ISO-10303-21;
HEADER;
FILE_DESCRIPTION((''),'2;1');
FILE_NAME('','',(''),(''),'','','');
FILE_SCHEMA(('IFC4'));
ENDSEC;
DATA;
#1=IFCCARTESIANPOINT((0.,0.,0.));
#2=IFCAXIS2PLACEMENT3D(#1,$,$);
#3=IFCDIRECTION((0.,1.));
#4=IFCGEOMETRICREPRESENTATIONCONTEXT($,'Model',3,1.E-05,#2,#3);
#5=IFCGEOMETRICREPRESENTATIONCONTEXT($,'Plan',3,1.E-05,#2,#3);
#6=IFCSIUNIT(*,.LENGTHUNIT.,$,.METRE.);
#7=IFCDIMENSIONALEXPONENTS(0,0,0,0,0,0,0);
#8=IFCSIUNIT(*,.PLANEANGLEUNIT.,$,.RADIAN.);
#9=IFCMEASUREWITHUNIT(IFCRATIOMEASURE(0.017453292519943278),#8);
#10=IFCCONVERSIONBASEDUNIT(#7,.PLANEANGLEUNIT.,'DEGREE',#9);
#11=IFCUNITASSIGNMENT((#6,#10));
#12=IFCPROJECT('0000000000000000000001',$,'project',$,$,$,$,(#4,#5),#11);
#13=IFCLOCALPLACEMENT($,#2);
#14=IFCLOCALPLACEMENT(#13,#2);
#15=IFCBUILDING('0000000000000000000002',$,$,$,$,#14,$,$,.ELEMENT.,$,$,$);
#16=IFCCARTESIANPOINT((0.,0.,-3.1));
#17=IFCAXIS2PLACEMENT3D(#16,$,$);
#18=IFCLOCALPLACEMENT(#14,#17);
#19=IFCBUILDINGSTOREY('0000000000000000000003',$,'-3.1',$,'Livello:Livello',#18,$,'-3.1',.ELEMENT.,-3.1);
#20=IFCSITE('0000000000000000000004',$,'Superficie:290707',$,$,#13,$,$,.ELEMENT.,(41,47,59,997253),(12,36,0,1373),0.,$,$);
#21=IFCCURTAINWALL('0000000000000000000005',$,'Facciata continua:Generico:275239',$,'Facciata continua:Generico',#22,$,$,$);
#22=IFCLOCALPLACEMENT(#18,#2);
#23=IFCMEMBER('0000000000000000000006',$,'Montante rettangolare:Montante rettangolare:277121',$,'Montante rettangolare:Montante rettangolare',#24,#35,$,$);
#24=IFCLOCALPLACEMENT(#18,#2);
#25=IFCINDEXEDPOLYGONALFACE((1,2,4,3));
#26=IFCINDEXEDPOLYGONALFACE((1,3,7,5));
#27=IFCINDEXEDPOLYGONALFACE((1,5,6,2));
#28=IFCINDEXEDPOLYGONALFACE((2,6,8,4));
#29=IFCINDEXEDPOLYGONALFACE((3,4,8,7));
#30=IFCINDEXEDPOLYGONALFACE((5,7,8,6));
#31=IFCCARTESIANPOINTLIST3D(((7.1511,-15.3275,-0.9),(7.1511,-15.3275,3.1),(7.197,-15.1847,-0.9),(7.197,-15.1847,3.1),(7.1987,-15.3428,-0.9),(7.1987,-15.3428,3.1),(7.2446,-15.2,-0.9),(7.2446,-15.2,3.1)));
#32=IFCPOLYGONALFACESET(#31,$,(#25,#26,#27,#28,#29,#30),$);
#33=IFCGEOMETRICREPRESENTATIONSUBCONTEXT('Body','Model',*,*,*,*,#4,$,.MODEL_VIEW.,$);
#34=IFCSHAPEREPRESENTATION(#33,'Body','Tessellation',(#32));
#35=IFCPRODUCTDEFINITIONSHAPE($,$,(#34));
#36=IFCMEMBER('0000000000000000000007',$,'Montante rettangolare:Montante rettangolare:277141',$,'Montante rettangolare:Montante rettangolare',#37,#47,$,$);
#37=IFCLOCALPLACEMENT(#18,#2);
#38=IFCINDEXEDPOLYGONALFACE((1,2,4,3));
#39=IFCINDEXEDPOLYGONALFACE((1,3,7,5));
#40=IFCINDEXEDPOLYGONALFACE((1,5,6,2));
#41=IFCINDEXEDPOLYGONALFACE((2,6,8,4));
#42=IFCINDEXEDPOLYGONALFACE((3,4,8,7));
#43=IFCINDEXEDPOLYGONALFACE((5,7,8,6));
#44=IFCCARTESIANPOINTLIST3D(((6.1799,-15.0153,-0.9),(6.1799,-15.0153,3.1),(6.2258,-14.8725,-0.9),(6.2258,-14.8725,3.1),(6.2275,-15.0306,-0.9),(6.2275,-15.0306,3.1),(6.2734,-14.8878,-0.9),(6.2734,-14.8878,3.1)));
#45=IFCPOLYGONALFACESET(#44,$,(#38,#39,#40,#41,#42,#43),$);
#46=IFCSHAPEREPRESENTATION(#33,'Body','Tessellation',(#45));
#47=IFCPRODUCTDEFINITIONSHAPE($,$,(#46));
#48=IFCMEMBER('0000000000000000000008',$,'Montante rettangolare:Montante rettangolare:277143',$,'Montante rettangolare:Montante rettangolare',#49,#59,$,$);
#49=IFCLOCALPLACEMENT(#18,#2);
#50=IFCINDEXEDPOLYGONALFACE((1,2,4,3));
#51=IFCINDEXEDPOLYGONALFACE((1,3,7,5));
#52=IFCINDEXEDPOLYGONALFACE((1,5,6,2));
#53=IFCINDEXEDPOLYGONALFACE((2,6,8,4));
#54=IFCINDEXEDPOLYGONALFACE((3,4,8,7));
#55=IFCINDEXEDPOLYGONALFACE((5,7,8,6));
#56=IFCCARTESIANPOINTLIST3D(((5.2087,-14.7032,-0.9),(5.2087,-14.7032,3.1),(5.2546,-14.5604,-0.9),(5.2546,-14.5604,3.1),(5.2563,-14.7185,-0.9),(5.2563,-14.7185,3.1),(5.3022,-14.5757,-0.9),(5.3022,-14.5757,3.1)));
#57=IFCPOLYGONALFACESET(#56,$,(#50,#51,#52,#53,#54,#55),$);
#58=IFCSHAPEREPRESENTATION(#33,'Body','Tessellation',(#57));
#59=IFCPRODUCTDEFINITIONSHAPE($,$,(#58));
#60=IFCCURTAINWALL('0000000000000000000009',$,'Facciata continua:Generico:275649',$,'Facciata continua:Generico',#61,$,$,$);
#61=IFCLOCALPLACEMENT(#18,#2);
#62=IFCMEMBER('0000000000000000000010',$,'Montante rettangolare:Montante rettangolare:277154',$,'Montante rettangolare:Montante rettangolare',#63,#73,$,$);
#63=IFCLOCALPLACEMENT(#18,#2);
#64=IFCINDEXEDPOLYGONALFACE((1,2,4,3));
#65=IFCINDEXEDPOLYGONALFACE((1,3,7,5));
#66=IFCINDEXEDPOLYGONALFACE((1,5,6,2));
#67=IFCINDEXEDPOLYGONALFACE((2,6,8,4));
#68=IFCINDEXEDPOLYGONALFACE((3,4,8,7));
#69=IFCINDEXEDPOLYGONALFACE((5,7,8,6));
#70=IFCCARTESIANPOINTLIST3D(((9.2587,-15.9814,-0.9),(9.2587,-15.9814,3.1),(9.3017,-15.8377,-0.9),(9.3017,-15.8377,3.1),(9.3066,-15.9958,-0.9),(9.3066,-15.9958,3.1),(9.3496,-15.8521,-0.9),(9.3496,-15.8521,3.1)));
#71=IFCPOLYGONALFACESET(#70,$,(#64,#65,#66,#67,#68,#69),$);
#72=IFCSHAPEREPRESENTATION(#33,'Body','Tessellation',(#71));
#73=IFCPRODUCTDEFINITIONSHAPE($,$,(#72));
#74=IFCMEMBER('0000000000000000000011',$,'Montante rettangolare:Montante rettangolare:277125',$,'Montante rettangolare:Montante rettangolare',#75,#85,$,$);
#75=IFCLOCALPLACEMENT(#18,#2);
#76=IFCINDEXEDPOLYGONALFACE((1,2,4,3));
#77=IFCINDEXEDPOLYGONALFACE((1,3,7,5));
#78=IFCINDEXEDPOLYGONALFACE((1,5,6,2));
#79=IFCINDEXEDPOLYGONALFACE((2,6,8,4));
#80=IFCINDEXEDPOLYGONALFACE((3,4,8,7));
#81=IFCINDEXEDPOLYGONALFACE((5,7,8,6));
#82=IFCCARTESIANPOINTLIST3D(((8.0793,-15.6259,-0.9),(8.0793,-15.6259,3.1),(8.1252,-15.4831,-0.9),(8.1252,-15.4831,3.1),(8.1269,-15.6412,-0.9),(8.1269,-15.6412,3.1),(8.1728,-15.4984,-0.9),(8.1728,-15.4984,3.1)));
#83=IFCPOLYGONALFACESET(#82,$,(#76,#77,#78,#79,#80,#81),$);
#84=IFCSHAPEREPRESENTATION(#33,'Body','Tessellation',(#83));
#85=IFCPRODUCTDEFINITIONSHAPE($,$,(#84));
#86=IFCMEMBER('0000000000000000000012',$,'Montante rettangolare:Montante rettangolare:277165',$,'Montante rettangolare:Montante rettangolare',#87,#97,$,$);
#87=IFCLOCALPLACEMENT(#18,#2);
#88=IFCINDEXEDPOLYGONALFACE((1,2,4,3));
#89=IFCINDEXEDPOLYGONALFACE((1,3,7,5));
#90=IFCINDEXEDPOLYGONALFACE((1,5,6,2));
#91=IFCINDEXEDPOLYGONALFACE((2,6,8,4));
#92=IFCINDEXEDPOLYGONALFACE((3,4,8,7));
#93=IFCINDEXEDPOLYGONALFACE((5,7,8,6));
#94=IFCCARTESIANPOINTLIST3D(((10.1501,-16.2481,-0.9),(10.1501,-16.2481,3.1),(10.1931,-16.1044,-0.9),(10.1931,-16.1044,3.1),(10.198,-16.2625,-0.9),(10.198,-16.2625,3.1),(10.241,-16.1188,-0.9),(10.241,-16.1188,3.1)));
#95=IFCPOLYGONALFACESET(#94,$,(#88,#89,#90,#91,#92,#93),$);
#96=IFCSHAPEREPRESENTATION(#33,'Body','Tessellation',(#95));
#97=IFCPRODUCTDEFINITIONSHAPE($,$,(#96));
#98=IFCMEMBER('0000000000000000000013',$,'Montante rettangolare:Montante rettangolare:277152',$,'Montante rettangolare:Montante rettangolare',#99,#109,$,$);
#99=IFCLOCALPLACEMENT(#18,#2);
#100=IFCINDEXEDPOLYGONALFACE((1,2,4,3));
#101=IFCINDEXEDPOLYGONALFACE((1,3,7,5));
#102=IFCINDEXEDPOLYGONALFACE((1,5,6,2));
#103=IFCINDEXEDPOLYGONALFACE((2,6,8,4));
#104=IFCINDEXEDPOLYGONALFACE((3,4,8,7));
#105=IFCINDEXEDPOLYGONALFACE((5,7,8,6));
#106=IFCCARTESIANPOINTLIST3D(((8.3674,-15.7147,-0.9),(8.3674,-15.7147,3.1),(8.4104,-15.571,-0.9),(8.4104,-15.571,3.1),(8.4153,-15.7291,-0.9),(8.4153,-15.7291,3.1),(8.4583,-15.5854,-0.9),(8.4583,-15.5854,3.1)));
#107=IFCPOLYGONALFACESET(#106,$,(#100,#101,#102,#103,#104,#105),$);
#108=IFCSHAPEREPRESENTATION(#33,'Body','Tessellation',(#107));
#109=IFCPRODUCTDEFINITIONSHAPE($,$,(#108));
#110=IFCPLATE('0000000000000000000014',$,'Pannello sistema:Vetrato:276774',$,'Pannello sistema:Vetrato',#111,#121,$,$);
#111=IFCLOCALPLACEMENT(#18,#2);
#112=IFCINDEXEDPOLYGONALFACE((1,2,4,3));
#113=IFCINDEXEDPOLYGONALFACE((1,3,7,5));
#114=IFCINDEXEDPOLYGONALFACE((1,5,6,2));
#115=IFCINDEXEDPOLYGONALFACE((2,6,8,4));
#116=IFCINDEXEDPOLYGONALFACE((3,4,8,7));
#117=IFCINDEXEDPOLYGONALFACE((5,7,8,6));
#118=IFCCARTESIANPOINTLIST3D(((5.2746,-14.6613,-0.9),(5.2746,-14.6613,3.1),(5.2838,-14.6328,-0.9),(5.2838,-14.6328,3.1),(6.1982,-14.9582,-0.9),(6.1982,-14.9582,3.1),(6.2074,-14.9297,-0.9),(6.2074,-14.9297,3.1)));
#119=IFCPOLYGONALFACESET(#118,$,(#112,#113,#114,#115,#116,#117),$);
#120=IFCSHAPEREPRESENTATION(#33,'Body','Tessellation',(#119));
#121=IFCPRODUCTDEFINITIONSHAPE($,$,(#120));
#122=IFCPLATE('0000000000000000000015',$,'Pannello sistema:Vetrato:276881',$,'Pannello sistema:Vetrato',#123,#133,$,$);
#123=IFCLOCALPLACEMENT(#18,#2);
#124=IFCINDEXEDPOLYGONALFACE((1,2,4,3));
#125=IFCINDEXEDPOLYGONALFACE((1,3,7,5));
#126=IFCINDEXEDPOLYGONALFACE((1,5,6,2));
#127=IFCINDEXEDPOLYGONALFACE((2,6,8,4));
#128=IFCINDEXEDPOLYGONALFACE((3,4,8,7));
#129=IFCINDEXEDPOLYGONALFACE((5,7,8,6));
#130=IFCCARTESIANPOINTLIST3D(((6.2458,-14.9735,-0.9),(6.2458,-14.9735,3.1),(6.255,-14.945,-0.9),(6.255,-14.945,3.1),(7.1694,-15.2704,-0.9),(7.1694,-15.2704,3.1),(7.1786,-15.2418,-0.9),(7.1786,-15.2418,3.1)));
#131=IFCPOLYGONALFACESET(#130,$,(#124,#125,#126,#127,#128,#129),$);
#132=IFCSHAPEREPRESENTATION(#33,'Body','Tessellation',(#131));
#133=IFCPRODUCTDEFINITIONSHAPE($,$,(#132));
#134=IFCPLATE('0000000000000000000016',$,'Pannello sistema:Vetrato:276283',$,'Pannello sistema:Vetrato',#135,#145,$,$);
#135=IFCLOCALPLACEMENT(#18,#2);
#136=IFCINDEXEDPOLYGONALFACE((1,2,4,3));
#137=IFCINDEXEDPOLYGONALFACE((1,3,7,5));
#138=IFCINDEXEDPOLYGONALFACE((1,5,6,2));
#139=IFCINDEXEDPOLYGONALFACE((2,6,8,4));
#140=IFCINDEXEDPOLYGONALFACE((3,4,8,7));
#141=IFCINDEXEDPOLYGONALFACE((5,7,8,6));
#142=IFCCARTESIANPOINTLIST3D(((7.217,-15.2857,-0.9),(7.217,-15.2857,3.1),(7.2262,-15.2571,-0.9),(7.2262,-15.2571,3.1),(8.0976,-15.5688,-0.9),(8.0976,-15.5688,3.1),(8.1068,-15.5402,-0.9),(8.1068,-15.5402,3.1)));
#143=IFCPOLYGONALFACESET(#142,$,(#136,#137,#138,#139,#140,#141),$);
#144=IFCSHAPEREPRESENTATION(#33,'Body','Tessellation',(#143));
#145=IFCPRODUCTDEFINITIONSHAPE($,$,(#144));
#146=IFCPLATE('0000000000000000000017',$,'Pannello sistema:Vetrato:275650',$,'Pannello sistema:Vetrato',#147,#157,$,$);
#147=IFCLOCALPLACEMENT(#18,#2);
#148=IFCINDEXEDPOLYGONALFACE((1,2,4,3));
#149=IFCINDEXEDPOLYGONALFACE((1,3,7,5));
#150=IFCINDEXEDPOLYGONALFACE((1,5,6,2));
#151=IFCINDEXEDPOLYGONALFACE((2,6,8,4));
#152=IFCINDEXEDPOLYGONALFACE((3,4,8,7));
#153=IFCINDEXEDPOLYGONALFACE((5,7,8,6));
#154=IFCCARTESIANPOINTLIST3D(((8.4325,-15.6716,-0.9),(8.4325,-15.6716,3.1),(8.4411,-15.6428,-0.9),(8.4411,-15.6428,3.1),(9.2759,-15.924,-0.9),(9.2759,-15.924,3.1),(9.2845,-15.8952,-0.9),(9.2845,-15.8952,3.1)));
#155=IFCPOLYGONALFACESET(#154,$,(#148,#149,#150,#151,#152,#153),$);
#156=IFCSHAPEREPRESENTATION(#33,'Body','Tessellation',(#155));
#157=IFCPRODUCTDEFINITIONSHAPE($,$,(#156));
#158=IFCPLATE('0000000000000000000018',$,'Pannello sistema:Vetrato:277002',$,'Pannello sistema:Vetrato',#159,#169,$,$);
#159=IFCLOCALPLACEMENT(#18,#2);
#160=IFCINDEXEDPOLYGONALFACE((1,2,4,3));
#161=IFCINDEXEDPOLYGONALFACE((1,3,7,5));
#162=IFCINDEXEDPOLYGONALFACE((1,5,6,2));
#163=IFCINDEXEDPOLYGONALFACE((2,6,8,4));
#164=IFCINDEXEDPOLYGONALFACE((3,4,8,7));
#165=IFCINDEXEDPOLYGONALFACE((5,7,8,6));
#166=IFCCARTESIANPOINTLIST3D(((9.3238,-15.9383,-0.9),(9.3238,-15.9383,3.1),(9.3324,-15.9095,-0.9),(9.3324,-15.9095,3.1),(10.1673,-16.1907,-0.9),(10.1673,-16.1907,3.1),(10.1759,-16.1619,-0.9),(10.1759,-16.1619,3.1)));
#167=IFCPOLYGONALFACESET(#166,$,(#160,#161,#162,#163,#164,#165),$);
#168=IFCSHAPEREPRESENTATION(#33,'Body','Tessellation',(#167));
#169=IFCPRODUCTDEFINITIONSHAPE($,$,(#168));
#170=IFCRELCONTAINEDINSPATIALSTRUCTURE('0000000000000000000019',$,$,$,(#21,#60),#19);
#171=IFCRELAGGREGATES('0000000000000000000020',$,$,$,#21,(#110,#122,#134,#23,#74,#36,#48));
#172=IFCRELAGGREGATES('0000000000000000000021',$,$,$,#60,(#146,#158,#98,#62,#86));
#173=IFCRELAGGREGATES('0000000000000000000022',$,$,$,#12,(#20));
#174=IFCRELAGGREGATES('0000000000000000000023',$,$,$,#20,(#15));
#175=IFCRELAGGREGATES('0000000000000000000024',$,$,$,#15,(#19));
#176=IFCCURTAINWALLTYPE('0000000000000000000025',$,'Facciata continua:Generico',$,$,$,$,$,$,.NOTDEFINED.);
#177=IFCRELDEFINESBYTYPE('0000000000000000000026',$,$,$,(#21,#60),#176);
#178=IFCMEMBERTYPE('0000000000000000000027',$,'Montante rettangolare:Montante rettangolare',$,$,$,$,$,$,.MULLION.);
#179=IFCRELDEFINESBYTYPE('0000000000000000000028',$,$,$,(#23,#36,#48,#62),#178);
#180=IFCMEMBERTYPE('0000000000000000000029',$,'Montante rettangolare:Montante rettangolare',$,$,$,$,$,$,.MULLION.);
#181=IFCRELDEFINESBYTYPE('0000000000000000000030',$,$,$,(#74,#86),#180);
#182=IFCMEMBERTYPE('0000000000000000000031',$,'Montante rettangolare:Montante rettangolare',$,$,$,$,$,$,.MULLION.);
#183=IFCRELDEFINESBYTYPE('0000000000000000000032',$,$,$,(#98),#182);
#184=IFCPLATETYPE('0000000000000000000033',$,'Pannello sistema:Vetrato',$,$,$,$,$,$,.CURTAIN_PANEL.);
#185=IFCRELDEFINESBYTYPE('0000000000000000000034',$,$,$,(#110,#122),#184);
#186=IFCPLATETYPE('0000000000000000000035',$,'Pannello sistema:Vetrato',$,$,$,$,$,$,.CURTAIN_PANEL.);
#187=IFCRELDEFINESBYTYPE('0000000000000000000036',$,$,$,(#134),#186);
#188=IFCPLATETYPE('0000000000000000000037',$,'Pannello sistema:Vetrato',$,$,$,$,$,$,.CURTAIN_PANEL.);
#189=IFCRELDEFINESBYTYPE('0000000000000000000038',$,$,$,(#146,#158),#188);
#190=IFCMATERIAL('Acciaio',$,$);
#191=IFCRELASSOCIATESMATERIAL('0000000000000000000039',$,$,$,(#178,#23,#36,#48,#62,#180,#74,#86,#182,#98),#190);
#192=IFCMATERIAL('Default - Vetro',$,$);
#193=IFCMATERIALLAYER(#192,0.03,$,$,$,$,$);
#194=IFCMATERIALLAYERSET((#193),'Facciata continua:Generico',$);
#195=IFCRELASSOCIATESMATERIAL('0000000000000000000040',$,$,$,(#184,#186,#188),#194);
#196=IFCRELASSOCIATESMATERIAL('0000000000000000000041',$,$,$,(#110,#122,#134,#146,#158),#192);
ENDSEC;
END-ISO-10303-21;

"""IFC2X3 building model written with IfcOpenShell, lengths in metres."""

from ifc_helpers import new_model, entity, si_unit, converted_unit, direction, frame, frame_2d, origin, origin_2d_with_axis, place, context, subcontext, project, spatial, rectangle, extrude, source, transform, mapped, material, layer, layer_set, type_object, type_shapes, element, aggregate, save


model = new_model("IFC2X3")

# Units and contexts
model_context = context("Model", 3, precision=1e-05, world=origin(), true_north=direction((0.0, 1.0)))
plan_context = context("Plan", 3, precision=1e-05, world=origin(), true_north=direction((0.0, 1.0)))
body_context = subcontext(model_context, "Body", "Model", "MODEL_VIEW")
ifc_project = project(units=[si_unit("LENGTHUNIT", "METRE"), converted_unit("PLANEANGLEUNIT", "DEGREE", entity("IfcRatioMeasure", 0.017453292519943278), si_unit("PLANEANGLEUNIT", "RADIAN"), dimensions=[0, 0, 0, 0, 0, 0, 0])], contexts=[model_context, plan_context])

# Site, building, storey
site_placement = place(None, origin())
site = spatial("IfcSite", under=ifc_project, at=site_placement, Name="Superficie:290707", CompositionType="ELEMENT", RefLatitude=(41, 47, 59, 997253), RefLongitude=(12, 36, 0, 1373), RefElevation=0.0)
building_placement = place(site_placement, origin())
building = spatial("IfcBuilding", under=site, at=building_placement, CompositionType="ELEMENT")
storey_placement = place(building_placement, frame((0.0, 0.0, -3.1)))
storey = spatial("IfcBuildingStorey", under=building, at=storey_placement, Name="-3.1", ObjectType="Livello:Livello", LongName="-3.1", CompositionType="ELEMENT", Elevation=-3.1)

# Curtain wall, members
curtain_wall_type = type_object("IfcCurtainWallType", Name="Facciata continua:Generico", PredefinedType="NOTDEFINED")
curtain_wall_1_placement = place(storey_placement, frame((0.0, 0.0, 3.1)))
curtain_wall_1 = element("IfcCurtainWall", 1, at=curtain_wall_1_placement, inside=storey, type_object=curtain_wall_type, Name="Facciata continua:Generico:275239", ObjectType="Facciata continua:Generico")
ifc_material_1 = material(Name="Acciaio")
member_type_1 = type_object("IfcMemberType", Name="Montante rettangolare:Montante rettangolare", PredefinedType="MULLION", material=ifc_material_1)
shared_shape_1 = source(origin(), body_context, "Body", "SweptSolid", [
    extrude(rectangle(XDim=0.15, YDim=0.05, at=origin_2d_with_axis()), frame((0.0, 0.0, -4.0), z_axis=(0.0, 0.0, 1.0), x_axis=(0.0, -1.0, 0.0)), (0.0, 0.0, 1.0), 4.0),
])
type_shapes(member_type_1, [shared_shape_1])
member_1_placement = place(curtain_wall_1_placement, frame((7.1978, -15.2638, -4.0), z_axis=(0.0, 0.0, -1.0), x_axis=(0.952025, -0.30602, 0.0)))
member_1 = element("IfcMember", 2, at=member_1_placement, type_object=member_type_1, material=ifc_material_1, Name="Montante rettangolare:Montante rettangolare:277121", ObjectType="Montante rettangolare:Montante rettangolare", context=body_context, shape_type="MappedRepresentation", body=[
    mapped(shared_shape_1, transform((0.0, 0.0, 0.0), scale=1.0)),
])
member_2_placement = place(curtain_wall_1_placement, frame((6.2266, -14.9516, -4.0), z_axis=(0.0, 0.0, -1.0), x_axis=(0.952025, -0.30602, 0.0)))
member_2 = element("IfcMember", 3, at=member_2_placement, type_object=member_type_1, material=ifc_material_1, Name="Montante rettangolare:Montante rettangolare:277141", ObjectType="Montante rettangolare:Montante rettangolare", context=body_context, shape_type="MappedRepresentation", body=[
    mapped(shared_shape_1, transform((0.0, 0.0, 0.0), scale=1.0)),
])
member_3_placement = place(curtain_wall_1_placement, frame((5.2554, -14.6394, -4.0), z_axis=(0.0, 0.0, -1.0), x_axis=(0.952025, -0.30602, 0.0)))
member_3 = element("IfcMember", 4, at=member_3_placement, type_object=member_type_1, material=ifc_material_1, Name="Montante rettangolare:Montante rettangolare:277143", ObjectType="Montante rettangolare:Montante rettangolare", context=body_context, shape_type="MappedRepresentation", body=[
    mapped(shared_shape_1, transform((0.0, 0.0, 0.0), scale=1.0)),
])

# Curtain wall, member
curtain_wall_2_placement = place(storey_placement, frame((0.0, 0.0, 3.1)))
curtain_wall_2 = element("IfcCurtainWall", 5, at=curtain_wall_2_placement, inside=storey, type_object=curtain_wall_type, Name="Facciata continua:Generico:275649", ObjectType="Facciata continua:Generico")
member_4_placement = place(curtain_wall_2_placement, frame((9.3042, -15.9168, -4.0), z_axis=(0.0, 0.0, -1.0), x_axis=(0.95803, -0.286666, 0.0)))
member_4 = element("IfcMember", 6, at=member_4_placement, type_object=member_type_1, material=ifc_material_1, Name="Montante rettangolare:Montante rettangolare:277154", ObjectType="Montante rettangolare:Montante rettangolare", context=body_context, shape_type="MappedRepresentation", body=[
    mapped(shared_shape_1, transform((0.0, 0.0, 0.0), scale=1.0)),
])

# Members
member_type_2 = type_object("IfcMemberType", Name="Montante rettangolare:Montante rettangolare", PredefinedType="MULLION", material=ifc_material_1)
shared_shape_2 = source(origin(), body_context, "Body", "SweptSolid", [
    extrude(rectangle(XDim=0.15, YDim=0.05, at=origin_2d_with_axis()), frame((-0.025, 0.0, -4.0), z_axis=(0.0, 0.0, 1.0), x_axis=(0.0, -1.0, 0.0)), (0.0, 0.0, 1.0), 4.0),
])
type_shapes(member_type_2, [shared_shape_2])
member_5_placement = place(curtain_wall_1_placement, frame((8.1498, -15.5698, -4.0), z_axis=(0.0, 0.0, -1.0), x_axis=(0.952025, -0.30602, 0.0)))
member_5 = element("IfcMember", 7, at=member_5_placement, type_object=member_type_2, material=ifc_material_1, Name="Montante rettangolare:Montante rettangolare:277125", ObjectType="Montante rettangolare:Montante rettangolare", context=body_context, shape_type="MappedRepresentation", body=[
    mapped(shared_shape_2, transform((0.0, 0.0, 0.0), scale=1.0)),
])
member_6_placement = place(curtain_wall_2_placement, frame((10.2195, -16.1906, -4.0), z_axis=(0.0, 0.0, -1.0), x_axis=(0.95803, -0.286666, 0.0)))
member_6 = element("IfcMember", 8, at=member_6_placement, type_object=member_type_2, material=ifc_material_1, Name="Montante rettangolare:Montante rettangolare:277165", ObjectType="Montante rettangolare:Montante rettangolare", context=body_context, shape_type="MappedRepresentation", body=[
    mapped(shared_shape_2, transform((0.0, 0.0, 0.0), scale=1.0)),
])
member_type_3 = type_object("IfcMemberType", Name="Montante rettangolare:Montante rettangolare", PredefinedType="MULLION", material=ifc_material_1)
shared_shape_3 = source(origin(), body_context, "Body", "SweptSolid", [
    extrude(rectangle(XDim=0.15, YDim=0.05, at=origin_2d_with_axis()), frame((-0.025, 0.0, -4.0), z_axis=(0.0, 0.0, 1.0), x_axis=(0.0, -1.0, 0.0)), (0.0, 0.0, 1.0), 4.0),
])
type_shapes(member_type_3, [shared_shape_3])
member_7_placement = place(curtain_wall_2_placement, frame((8.3889, -15.6429, 0.0), z_axis=(0.0, 0.0, 1.0), x_axis=(-0.95803, 0.286666, 0.0)))
member_7 = element("IfcMember", 9, at=member_7_placement, type_object=member_type_3, material=ifc_material_1, Name="Montante rettangolare:Montante rettangolare:277152", ObjectType="Montante rettangolare:Montante rettangolare", context=body_context, shape_type="MappedRepresentation", body=[
    mapped(shared_shape_3, transform((0.0, 0.0, 0.0), scale=1.0)),
])

# Plates
ifc_material_2 = material(Name="Default - Vetro")
ifc_layer_1 = layer(ifc_material_2, 0.03)
ifc_layer_set_1 = layer_set([ifc_layer_1], Name="Facciata continua:Generico")
plate_type_1 = type_object("IfcPlateType", Name="Pannello sistema:Vetrato", PredefinedType="CURTAIN_PANEL", material=ifc_layer_set_1)
shared_shape_4 = source(origin(), body_context, "Body", "SweptSolid", [
    extrude(rectangle(XDim=0.03, YDim=0.9701, at=frame_2d((0.0, 0.0), x_axis=(1.0, 0.0))), frame((0.0, 0.0, 0.0), z_axis=(0.0, 0.0, 1.0), x_axis=(0.0, 1.0, 0.0)), (0.0, 0.0, 1.0), 4.0),
])
type_shapes(plate_type_1, [shared_shape_4])
plate_1_placement = place(curtain_wall_1_placement, frame((5.741, -14.7955, -4.0), z_axis=(0.0, 0.0, 1.0), x_axis=(0.952025, -0.30602, 0.0)))
plate_1 = element("IfcPlate", 10, at=plate_1_placement, type_object=plate_type_1, material=ifc_material_2, Name="Pannello sistema:Vetrato:276774", ObjectType="Pannello sistema:Vetrato", context=body_context, shape_type="MappedRepresentation", body=[
    mapped(shared_shape_4, transform((0.0, 0.0, 0.0), scale=1.0)),
])
plate_2_placement = place(curtain_wall_1_placement, frame((6.7122, -15.1077, -4.0), z_axis=(0.0, 0.0, 1.0), x_axis=(0.952025, -0.30602, 0.0)))
plate_2 = element("IfcPlate", 11, at=plate_2_placement, type_object=plate_type_1, material=ifc_material_2, Name="Pannello sistema:Vetrato:276881", ObjectType="Pannello sistema:Vetrato", context=body_context, shape_type="MappedRepresentation", body=[
    mapped(shared_shape_4, transform((0.0, 0.0, 0.0), scale=1.0)),
])
plate_type_2 = type_object("IfcPlateType", Name="Pannello sistema:Vetrato", PredefinedType="CURTAIN_PANEL", material=ifc_layer_set_1)
shared_shape_5 = source(origin(), body_context, "Body", "SweptSolid", [
    extrude(rectangle(XDim=0.03, YDim=0.925, at=frame_2d((0.0, 0.0), x_axis=(1.0, 0.0))), frame((0.0, 0.0, 0.0), z_axis=(0.0, 0.0, 1.0), x_axis=(0.0, 1.0, 0.0)), (0.0, 0.0, 1.0), 4.0),
])
type_shapes(plate_type_2, [shared_shape_5])
plate_3_placement = place(curtain_wall_1_placement, frame((7.6619, -15.413, -4.0), z_axis=(0.0, 0.0, 1.0), x_axis=(0.952025, -0.30602, 0.0)))
plate_3 = element("IfcPlate", 12, at=plate_3_placement, type_object=plate_type_2, material=ifc_material_2, Name="Pannello sistema:Vetrato:276283", ObjectType="Pannello sistema:Vetrato", context=body_context, shape_type="MappedRepresentation", body=[
    mapped(shared_shape_5, transform((0.0, 0.0, 0.0), scale=1.0)),
])
aggregate(curtain_wall_1, [plate_1, plate_2, plate_3, member_1, member_5, member_2, member_3])
plate_type_3 = type_object("IfcPlateType", Name="Pannello sistema:Vetrato", PredefinedType="CURTAIN_PANEL", material=ifc_layer_set_1)
shared_shape_6 = source(origin(), body_context, "Body", "SweptSolid", [
    extrude(rectangle(XDim=0.03, YDim=0.8804, at=frame_2d((0.0, 0.0), x_axis=(1.0, 0.0))), frame((0.0, 0.0, 0.0), z_axis=(0.0, 0.0, 1.0), x_axis=(0.0, 1.0, 0.0)), (0.0, 0.0, 1.0), 4.0),
])
type_shapes(plate_type_3, [shared_shape_6])
plate_4_placement = place(curtain_wall_2_placement, frame((8.8585, -15.7834, -4.0), z_axis=(0.0, 0.0, 1.0), x_axis=(0.95803, -0.286666, 0.0)))
plate_4 = element("IfcPlate", 13, at=plate_4_placement, type_object=plate_type_3, material=ifc_material_2, Name="Pannello sistema:Vetrato:275650", ObjectType="Pannello sistema:Vetrato", context=body_context, shape_type="MappedRepresentation", body=[
    mapped(shared_shape_6, transform((0.0, 0.0, 0.0), scale=1.0)),
])
plate_5_placement = place(curtain_wall_2_placement, frame((9.7498, -16.0501, -4.0), z_axis=(0.0, 0.0, 1.0), x_axis=(0.95803, -0.286666, 0.0)))
plate_5 = element("IfcPlate", 14, at=plate_5_placement, type_object=plate_type_3, material=ifc_material_2, Name="Pannello sistema:Vetrato:277002", ObjectType="Pannello sistema:Vetrato", context=body_context, shape_type="MappedRepresentation", body=[
    mapped(shared_shape_6, transform((0.0, 0.0, 0.0), scale=1.0)),
])
aggregate(curtain_wall_2, [plate_4, plate_5, member_7, member_4, member_6])

save(model, "model.ifc")
